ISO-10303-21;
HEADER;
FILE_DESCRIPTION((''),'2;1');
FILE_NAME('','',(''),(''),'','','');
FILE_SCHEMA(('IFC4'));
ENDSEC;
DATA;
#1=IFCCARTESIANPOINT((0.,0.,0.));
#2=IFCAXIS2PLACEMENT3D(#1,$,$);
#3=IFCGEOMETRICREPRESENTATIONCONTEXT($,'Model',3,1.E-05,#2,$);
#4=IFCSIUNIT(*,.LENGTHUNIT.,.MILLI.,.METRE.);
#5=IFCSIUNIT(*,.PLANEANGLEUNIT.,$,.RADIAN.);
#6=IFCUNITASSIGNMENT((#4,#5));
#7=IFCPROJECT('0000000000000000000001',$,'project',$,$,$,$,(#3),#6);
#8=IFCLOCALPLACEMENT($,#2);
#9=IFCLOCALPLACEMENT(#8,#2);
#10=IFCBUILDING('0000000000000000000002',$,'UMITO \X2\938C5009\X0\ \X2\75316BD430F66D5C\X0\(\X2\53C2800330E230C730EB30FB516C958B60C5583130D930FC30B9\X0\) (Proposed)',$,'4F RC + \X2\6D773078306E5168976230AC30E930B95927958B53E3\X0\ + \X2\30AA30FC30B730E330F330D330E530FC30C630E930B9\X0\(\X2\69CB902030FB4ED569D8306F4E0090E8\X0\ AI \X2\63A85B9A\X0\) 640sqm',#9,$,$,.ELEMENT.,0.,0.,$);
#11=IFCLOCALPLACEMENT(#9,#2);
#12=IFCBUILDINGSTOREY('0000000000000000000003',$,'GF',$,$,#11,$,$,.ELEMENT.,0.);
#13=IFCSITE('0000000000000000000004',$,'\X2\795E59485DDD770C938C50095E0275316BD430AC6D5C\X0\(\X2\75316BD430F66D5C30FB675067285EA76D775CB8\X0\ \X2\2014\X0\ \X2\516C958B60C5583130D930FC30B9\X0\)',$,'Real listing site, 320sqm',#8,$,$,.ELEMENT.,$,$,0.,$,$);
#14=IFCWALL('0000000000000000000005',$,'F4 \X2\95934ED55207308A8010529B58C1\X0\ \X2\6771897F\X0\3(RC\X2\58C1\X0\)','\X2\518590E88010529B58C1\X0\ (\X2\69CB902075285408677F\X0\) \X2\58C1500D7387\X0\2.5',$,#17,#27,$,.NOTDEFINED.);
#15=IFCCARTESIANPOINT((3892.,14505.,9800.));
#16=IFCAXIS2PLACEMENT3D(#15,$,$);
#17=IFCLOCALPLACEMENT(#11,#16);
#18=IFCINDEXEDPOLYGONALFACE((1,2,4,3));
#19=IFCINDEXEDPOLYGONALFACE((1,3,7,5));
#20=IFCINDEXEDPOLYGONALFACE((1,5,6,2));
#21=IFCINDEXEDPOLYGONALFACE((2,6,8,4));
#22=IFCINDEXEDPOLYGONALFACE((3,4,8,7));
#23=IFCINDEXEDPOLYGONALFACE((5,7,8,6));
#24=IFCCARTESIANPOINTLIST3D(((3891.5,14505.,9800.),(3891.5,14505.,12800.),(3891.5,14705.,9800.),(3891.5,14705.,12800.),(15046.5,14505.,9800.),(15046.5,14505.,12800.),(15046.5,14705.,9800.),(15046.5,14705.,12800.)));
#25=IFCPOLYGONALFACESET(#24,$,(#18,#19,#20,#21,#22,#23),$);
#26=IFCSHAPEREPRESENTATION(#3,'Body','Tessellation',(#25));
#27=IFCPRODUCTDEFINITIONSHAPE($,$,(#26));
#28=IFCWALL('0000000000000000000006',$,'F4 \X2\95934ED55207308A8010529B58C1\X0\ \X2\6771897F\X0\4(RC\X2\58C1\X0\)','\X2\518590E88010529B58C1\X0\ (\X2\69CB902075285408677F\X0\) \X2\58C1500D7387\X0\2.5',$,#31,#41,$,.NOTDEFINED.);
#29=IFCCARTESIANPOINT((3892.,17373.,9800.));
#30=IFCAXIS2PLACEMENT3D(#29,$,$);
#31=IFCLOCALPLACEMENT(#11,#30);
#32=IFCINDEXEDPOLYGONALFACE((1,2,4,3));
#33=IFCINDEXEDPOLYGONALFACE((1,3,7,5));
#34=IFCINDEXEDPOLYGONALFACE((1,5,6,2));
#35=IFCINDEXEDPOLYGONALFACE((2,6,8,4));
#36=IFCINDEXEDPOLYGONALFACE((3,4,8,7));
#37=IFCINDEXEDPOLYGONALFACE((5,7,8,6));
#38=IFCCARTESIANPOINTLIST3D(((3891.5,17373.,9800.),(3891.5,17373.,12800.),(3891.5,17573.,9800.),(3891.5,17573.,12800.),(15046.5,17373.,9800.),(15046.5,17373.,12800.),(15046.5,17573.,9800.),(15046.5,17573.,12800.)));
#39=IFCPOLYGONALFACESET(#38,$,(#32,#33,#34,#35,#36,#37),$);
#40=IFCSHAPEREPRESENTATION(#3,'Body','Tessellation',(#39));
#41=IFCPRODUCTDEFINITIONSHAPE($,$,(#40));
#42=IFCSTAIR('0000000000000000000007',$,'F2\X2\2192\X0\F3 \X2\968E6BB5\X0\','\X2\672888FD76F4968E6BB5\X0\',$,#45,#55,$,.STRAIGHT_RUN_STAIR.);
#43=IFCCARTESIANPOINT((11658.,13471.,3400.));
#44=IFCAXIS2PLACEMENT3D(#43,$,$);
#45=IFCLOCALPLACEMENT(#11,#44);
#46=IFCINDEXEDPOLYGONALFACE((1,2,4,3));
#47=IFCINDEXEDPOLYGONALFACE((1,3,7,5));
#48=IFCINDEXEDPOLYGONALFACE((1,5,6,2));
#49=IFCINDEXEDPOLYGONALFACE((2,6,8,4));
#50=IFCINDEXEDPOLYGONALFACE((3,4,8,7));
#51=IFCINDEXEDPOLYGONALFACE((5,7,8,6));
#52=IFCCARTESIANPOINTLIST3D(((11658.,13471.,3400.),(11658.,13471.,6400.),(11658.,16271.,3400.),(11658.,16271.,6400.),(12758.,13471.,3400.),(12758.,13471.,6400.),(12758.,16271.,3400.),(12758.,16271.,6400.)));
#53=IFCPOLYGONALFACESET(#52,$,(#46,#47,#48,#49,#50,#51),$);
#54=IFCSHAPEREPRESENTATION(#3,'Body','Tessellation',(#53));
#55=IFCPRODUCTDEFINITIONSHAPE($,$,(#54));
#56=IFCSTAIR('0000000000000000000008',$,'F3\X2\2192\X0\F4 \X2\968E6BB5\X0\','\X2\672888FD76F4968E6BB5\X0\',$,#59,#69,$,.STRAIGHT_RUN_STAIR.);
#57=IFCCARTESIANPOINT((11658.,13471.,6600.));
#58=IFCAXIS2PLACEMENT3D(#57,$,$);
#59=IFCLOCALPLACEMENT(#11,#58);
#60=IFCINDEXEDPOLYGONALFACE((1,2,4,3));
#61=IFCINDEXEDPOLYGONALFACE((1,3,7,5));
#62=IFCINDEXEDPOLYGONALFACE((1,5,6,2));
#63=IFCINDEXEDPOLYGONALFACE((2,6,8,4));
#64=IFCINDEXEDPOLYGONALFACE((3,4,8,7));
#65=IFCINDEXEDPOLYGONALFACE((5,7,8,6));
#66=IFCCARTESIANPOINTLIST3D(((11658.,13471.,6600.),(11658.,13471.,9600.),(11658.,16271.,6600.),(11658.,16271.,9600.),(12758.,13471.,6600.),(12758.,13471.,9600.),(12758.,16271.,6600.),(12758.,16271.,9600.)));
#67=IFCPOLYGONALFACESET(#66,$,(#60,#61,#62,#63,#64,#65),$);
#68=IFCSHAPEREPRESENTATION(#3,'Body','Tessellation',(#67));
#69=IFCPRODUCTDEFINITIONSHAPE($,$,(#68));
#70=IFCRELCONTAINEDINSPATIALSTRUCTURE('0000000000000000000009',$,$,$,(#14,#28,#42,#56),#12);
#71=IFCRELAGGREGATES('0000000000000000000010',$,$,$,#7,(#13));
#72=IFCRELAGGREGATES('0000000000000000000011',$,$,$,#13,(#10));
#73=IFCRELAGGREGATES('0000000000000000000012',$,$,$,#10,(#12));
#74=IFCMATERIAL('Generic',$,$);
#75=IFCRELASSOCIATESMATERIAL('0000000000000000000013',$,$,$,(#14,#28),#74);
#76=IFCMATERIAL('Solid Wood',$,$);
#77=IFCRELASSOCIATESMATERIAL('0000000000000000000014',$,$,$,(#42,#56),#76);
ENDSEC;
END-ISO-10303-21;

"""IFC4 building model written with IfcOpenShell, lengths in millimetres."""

from ifc_helpers import new_model, si_unit, frame, frame_2d, origin, place, context, project, spatial, rectangle, extrude, material, element, save


model = new_model("IFC4")

# Units and contexts
model_context = context("Model", 3, precision=1e-05, world=origin())
ifc_project = project(units=[si_unit("LENGTHUNIT", "METRE", prefix="MILLI"), si_unit("PLANEANGLEUNIT", "RADIAN")], contexts=[model_context])

# Site, building, storey
site_placement = place(None, origin())
site = spatial("IfcSite", under=ifc_project, at=site_placement, Name="神奈川県鎌倉市由比ガ浜(由比ヶ浜・材木座海岸 — 公開情報ベース)", ObjectType="Real listing site, 320sqm", CompositionType="ELEMENT", RefElevation=0.0)
building_placement = place(site_placement, origin())
building = spatial("IfcBuilding", under=site, at=building_placement, Name="UMITO 鎌倉 由比ヶ浜(参考モデル・公開情報ベース) (Proposed)", ObjectType="4F RC + 海への全面ガラス大開口 + オーシャンビューテラス(構造・仕様は一部 AI 推定) 640sqm", CompositionType="ELEMENT", ElevationOfRefHeight=0.0, ElevationOfTerrain=0.0)
storey_placement = place(building_placement, origin())
storey = spatial("IfcBuildingStorey", under=building, at=storey_placement, Name="GF", CompositionType="ELEMENT", Elevation=0.0)

# Shared definitions
ifc_material_1 = material(Name="Generic")

# Walls
wall_1_placement = place(storey_placement, frame((3892.0, 14505.0, 9800.0)))
element("IfcWall", 1, at=wall_1_placement, inside=storey, material=ifc_material_1, Name="F4 間仕切り耐力壁 東西3(RC壁)", Description="内部耐力壁 (構造用合板) 壁倍率2.5", PredefinedType="NOTDEFINED", context=model_context, shape_type="SweptSolid", body=[
    extrude(rectangle(XDim=11155.0, YDim=200.0, at=frame_2d((5577.0, 100.0))), frame((3892.0, 14505.0, 9800.0)), (0.0, 0.0, 1.0), 3000.0),
])
wall_2_placement = place(storey_placement, frame((3892.0, 17373.0, 9800.0)))
element("IfcWall", 2, at=wall_2_placement, inside=storey, material=ifc_material_1, Name="F4 間仕切り耐力壁 東西4(RC壁)", Description="内部耐力壁 (構造用合板) 壁倍率2.5", PredefinedType="NOTDEFINED", context=model_context, shape_type="SweptSolid", body=[
    extrude(rectangle(XDim=11155.0, YDim=200.0, at=frame_2d((5577.0, 100.0))), frame((3892.0, 17373.0, 9800.0)), (0.0, 0.0, 1.0), 3000.0),
])

# Stairs
ifc_material_2 = material(Name="Solid Wood")
stair_1_placement = place(storey_placement, frame((11658.0, 13471.0, 3400.0)))
element("IfcStair", 3, at=stair_1_placement, inside=storey, material=ifc_material_2, Name="F2→F3 階段", Description="木製直階段", PredefinedType="STRAIGHT_RUN_STAIR", context=model_context, shape_type="SweptSolid", body=[
    extrude(rectangle(XDim=1100.0, YDim=2800.0, at=frame_2d((550.0, 1400.0))), frame((11658.0, 13471.0, 3400.0)), (0.0, 0.0, 1.0), 3000.0),
])
stair_2_placement = place(storey_placement, frame((11658.0, 13471.0, 6600.0)))
element("IfcStair", 4, at=stair_2_placement, inside=storey, material=ifc_material_2, Name="F3→F4 階段", Description="木製直階段", PredefinedType="STRAIGHT_RUN_STAIR", context=model_context, shape_type="SweptSolid", body=[
    extrude(rectangle(XDim=1100.0, YDim=2800.0, at=frame_2d((550.0, 1400.0))), frame((11658.0, 13471.0, 6600.0)), (0.0, 0.0, 1.0), 3000.0),
])

save(model, "model.ifc")
